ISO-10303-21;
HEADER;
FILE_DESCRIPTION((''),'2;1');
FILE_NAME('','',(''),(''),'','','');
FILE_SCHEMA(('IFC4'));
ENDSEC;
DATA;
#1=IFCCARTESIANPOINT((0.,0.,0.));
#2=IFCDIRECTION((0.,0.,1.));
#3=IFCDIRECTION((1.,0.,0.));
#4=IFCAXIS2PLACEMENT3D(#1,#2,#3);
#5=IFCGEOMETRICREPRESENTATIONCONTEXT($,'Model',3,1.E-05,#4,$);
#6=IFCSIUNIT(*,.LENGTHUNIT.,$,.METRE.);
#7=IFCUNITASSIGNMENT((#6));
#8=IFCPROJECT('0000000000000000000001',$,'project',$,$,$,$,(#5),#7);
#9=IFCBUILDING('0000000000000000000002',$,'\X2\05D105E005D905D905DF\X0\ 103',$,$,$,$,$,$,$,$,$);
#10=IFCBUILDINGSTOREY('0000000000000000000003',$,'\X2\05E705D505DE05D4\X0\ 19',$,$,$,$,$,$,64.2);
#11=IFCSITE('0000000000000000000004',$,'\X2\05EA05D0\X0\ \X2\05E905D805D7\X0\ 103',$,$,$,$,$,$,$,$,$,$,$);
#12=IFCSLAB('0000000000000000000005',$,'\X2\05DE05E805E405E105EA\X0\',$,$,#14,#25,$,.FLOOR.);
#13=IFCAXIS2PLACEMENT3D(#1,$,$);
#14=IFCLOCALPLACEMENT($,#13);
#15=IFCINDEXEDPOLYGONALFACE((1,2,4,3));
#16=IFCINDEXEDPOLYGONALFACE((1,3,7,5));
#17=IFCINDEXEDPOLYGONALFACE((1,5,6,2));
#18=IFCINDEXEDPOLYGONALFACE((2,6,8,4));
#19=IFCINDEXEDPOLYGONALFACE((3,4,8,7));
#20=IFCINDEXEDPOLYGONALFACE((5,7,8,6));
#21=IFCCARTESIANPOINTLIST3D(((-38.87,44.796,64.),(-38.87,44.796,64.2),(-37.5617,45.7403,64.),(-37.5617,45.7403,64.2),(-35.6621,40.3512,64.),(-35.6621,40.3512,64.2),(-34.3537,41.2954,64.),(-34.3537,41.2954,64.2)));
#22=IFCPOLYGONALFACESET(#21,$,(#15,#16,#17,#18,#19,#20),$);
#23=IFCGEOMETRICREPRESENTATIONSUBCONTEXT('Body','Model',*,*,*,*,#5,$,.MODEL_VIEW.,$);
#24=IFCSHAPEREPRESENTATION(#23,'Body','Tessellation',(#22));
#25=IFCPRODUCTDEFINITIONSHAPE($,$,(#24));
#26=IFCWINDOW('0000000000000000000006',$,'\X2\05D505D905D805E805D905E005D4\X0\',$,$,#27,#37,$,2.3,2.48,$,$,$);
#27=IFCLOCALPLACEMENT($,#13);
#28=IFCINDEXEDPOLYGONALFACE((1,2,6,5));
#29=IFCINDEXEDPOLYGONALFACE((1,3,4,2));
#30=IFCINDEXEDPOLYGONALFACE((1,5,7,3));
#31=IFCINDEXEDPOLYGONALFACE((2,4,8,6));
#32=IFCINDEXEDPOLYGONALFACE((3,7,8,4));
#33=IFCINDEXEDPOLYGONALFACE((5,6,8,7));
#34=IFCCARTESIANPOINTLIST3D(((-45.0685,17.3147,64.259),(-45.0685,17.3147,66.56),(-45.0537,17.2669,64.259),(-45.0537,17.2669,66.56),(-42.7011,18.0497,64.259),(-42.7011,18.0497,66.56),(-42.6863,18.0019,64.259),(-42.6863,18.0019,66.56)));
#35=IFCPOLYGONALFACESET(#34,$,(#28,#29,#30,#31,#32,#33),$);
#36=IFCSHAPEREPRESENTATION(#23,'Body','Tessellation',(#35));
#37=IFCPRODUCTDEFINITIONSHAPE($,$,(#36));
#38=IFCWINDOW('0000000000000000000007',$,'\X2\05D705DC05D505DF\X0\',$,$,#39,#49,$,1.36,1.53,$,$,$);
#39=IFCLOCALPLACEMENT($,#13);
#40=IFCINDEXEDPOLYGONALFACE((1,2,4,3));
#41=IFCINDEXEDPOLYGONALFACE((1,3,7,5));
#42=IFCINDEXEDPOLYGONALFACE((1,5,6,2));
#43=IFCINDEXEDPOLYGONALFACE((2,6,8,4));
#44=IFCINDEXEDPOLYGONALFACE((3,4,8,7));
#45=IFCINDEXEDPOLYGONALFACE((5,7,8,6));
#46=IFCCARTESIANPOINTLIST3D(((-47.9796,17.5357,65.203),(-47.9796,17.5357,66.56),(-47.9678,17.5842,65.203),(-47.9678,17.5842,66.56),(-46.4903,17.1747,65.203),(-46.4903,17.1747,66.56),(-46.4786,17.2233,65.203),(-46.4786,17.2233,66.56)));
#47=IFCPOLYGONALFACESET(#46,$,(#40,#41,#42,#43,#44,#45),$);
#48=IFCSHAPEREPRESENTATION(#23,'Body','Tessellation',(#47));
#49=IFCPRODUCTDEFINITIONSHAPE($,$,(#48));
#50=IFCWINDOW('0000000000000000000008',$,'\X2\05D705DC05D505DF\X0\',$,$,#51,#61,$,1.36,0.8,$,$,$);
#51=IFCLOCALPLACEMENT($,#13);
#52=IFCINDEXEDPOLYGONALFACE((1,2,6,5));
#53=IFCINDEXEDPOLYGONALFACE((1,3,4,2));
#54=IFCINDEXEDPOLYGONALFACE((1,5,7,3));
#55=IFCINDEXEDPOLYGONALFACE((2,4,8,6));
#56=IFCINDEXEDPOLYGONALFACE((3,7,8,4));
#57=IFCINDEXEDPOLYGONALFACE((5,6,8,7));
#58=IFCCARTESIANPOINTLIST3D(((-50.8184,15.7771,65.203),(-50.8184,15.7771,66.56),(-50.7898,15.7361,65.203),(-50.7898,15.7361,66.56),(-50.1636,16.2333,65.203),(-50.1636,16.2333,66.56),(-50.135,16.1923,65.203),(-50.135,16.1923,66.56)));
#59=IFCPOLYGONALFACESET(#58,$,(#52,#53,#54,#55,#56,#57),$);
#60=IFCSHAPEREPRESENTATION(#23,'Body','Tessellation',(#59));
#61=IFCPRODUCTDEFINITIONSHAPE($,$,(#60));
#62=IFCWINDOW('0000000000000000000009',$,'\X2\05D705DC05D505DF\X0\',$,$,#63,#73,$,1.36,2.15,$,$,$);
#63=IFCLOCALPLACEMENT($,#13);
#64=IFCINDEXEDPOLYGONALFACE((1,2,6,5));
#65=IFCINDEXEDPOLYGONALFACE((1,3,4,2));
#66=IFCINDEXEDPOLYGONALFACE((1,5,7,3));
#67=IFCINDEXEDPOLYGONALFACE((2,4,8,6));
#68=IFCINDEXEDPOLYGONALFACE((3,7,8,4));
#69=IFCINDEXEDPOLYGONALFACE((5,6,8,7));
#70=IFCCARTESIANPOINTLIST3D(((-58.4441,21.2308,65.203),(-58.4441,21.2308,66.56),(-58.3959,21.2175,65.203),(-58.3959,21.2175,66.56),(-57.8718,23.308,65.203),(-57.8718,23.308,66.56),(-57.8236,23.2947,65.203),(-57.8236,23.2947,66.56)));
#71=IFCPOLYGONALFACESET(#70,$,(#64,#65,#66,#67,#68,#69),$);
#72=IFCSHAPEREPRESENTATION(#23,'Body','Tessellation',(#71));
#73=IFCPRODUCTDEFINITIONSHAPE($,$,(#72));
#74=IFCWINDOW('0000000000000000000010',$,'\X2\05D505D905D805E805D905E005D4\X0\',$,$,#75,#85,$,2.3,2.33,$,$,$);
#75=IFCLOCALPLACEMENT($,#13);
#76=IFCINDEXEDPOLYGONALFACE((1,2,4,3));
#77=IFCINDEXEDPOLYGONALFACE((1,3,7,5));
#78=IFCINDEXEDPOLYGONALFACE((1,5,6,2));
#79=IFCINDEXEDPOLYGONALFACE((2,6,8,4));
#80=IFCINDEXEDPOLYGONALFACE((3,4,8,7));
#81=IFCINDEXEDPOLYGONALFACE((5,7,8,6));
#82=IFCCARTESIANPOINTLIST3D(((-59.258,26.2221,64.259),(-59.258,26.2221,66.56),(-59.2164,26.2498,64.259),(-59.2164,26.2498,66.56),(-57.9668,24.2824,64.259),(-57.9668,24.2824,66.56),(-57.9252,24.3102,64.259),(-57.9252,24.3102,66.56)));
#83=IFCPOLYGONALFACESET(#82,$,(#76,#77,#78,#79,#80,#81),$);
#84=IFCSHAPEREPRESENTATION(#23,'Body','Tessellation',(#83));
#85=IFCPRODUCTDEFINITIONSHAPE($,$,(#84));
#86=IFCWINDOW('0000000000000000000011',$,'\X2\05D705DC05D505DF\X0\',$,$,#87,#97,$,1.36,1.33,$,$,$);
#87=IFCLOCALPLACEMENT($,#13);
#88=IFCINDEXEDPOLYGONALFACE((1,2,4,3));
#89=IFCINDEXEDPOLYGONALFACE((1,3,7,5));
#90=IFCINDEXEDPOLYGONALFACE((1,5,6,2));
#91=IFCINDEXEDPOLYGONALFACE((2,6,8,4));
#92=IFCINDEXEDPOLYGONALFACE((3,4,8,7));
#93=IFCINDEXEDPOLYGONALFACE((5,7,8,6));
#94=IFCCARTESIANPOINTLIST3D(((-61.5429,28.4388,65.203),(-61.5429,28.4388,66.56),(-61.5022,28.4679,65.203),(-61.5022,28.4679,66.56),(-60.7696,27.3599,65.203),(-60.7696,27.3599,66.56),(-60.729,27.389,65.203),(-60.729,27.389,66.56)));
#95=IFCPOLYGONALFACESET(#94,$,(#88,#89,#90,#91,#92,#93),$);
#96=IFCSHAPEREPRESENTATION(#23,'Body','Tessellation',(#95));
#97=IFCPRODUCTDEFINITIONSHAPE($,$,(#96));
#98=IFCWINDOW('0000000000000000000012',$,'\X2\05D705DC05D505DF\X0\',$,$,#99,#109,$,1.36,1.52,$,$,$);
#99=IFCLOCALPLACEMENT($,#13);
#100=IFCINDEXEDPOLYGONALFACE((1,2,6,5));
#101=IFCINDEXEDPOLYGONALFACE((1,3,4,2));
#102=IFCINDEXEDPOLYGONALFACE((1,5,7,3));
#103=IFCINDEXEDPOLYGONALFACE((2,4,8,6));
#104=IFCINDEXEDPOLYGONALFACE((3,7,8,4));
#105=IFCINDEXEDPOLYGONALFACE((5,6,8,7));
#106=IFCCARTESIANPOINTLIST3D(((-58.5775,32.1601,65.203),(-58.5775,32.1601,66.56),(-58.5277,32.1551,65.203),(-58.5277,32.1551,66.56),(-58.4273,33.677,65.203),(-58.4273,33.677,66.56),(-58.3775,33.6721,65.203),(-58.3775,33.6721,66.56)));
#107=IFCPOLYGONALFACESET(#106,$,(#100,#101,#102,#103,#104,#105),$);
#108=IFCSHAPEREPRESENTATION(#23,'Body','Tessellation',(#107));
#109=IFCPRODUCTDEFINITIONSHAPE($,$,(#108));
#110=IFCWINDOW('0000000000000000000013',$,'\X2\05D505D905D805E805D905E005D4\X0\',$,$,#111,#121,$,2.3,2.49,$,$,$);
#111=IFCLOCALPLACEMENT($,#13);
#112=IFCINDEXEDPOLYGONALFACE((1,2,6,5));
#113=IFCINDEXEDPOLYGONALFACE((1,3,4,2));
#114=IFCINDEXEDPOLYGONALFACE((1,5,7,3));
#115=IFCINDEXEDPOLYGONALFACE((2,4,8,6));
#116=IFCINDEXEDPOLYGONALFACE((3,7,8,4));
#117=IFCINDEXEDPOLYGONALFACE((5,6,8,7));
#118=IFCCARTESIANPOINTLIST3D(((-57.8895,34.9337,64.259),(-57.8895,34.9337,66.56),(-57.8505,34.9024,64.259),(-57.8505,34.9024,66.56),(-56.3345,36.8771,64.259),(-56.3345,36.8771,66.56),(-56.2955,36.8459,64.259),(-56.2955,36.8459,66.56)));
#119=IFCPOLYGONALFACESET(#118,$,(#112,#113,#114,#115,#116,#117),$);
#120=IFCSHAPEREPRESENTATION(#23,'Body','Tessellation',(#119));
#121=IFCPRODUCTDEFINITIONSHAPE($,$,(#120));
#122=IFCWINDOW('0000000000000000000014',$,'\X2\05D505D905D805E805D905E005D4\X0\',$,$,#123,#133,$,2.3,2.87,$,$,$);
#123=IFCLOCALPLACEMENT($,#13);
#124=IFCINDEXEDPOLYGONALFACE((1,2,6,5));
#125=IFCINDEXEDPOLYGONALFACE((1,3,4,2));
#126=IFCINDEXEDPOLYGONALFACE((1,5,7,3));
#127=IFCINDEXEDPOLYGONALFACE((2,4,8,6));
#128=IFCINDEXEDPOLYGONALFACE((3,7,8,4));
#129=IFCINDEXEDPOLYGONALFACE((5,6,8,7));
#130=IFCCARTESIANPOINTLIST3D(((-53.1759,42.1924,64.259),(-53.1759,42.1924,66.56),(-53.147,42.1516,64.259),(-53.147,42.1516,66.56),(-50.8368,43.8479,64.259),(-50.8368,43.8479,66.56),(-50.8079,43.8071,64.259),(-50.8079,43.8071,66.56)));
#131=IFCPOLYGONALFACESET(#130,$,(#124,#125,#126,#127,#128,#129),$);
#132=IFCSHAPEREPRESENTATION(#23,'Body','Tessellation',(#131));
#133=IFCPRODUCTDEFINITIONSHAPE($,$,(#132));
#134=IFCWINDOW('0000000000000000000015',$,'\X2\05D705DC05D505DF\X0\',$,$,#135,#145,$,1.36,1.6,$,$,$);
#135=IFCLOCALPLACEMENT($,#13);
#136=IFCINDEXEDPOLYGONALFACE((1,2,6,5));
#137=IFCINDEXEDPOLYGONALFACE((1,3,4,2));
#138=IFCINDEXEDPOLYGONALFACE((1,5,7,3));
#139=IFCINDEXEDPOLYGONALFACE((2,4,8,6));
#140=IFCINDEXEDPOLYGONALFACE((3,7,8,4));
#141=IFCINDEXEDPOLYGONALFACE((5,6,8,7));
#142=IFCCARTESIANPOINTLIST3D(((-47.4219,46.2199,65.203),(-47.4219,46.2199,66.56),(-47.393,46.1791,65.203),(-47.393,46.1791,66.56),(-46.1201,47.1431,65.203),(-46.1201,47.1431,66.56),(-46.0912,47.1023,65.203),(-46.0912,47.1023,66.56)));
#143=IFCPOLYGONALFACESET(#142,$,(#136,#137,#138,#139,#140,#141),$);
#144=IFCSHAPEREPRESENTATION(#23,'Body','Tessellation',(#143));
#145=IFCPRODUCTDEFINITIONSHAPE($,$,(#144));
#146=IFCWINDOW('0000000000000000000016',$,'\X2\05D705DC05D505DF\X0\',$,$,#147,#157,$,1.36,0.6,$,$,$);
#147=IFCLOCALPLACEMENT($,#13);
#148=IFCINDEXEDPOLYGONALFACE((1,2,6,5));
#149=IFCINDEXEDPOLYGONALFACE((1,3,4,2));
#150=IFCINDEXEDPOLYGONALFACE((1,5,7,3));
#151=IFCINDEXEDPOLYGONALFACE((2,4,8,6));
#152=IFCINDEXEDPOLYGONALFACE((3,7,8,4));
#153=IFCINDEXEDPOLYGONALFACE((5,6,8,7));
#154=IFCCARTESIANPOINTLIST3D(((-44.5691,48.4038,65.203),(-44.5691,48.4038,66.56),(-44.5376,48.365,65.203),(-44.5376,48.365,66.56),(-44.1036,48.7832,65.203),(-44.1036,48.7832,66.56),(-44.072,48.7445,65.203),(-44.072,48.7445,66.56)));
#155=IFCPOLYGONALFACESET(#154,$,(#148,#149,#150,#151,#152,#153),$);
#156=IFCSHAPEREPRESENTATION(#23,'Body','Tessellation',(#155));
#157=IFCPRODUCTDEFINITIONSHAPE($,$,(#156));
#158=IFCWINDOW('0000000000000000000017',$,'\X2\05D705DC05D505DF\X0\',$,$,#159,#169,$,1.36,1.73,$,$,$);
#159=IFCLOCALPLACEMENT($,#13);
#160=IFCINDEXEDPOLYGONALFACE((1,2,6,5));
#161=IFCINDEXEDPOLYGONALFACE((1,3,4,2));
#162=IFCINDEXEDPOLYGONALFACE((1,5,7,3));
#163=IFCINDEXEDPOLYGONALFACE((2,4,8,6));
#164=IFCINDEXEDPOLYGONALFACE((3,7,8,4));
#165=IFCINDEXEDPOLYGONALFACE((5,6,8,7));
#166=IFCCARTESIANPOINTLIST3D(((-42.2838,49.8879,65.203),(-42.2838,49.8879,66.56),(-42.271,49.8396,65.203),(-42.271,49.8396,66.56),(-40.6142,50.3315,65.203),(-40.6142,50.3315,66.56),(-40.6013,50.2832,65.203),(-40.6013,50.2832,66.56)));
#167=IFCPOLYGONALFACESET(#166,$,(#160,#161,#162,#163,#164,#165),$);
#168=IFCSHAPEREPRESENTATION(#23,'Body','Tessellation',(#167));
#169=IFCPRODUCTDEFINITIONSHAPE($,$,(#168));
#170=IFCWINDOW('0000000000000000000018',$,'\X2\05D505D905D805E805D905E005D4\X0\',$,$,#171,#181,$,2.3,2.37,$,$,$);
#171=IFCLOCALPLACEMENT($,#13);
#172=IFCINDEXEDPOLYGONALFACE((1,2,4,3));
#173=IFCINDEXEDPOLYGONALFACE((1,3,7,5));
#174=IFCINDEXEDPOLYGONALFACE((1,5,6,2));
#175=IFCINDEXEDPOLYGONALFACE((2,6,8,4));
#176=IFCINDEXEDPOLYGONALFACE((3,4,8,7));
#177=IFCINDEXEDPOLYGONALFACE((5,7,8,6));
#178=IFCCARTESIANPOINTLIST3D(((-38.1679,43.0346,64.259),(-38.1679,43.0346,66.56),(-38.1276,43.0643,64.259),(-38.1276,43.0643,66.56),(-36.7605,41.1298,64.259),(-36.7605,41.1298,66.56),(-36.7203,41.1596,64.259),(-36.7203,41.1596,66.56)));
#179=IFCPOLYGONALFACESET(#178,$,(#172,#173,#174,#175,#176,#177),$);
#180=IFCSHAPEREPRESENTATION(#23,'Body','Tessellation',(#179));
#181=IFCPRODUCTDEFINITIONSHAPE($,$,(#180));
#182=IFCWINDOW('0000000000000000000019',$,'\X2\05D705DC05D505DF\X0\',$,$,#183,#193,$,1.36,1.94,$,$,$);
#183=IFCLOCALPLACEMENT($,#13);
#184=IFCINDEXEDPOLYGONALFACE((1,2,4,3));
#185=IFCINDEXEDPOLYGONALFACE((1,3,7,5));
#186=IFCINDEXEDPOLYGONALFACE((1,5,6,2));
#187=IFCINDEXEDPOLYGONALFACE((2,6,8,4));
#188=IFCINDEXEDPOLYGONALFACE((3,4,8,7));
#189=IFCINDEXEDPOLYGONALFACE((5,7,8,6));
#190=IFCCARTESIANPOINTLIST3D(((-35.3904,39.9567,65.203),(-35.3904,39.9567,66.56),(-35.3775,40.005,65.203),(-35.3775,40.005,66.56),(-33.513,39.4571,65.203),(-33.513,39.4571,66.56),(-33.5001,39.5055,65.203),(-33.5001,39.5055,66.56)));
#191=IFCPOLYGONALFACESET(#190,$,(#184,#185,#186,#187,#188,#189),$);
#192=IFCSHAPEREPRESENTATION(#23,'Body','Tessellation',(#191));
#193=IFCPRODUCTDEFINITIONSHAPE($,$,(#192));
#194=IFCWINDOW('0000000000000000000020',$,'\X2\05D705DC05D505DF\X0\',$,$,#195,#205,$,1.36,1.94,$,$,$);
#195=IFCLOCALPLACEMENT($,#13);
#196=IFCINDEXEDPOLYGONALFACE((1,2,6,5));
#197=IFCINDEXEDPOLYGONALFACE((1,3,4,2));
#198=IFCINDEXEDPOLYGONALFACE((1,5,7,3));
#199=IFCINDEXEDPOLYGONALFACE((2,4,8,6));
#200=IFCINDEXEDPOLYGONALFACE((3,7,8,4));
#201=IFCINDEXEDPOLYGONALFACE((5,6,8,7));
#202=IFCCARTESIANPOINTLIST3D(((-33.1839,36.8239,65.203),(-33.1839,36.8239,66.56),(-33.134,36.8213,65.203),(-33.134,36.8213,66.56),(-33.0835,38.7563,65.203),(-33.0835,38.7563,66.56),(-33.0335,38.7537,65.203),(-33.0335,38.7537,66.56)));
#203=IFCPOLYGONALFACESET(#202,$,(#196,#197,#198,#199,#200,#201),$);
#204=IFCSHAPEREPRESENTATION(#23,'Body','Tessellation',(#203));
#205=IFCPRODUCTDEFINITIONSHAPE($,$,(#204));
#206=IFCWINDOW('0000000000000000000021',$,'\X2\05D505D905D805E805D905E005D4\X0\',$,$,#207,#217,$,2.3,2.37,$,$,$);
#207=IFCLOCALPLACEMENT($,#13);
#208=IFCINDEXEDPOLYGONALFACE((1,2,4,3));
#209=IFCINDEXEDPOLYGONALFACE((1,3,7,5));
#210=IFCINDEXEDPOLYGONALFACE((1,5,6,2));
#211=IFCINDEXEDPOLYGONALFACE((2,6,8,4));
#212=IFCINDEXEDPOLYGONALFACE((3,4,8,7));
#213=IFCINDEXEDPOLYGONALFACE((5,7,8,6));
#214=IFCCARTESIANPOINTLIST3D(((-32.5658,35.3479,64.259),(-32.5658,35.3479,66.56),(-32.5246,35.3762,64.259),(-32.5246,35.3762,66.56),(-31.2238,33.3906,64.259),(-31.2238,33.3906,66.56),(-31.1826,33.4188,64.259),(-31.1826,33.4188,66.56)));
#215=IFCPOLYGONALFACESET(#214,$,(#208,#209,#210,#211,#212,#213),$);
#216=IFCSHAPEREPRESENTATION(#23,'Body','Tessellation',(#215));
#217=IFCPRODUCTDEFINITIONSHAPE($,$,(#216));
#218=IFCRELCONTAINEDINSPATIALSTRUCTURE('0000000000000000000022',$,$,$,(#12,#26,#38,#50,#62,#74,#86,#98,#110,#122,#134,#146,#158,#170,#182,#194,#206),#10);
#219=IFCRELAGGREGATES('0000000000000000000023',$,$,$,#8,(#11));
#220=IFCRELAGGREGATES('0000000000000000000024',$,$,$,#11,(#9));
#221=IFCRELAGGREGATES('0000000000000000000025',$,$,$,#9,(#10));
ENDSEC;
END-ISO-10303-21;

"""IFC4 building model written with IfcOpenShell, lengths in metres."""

from ifc_helpers import new_model, si_unit, frame, origin_with_axes, context, subcontext, project, spatial, polyline, outline, extrude, element, save


model = new_model("IFC4")

# Units and contexts
model_context = context("Model", 3, precision=1e-05, world=origin_with_axes())
body_context = subcontext(model_context, "Body", "Model", "MODEL_VIEW")
ifc_project = project(units=[si_unit("LENGTHUNIT", "METRE")], contexts=[model_context])

# Site, building, storey
site = spatial("IfcSite", under=ifc_project, Name="תא שטח 103")
building = spatial("IfcBuilding", under=site, Name="בניין 103")
storey = spatial("IfcBuildingStorey", under=building, Name="קומה 19", Elevation=64.2)

# Slab
element("IfcSlab", 1, inside=storey, Name="מרפסת", PredefinedType="FLOOR", context=body_context, shape_type="SweptSolid", body=[
    extrude(outline(polyline([(-34.3537, 41.2954), (-37.5617, 45.7403), (-38.87, 44.796), (-35.6621, 40.3512), (-34.3537, 41.2954)])), frame((0.0, 0.0, 64.0)), (0.0, 0.0, 1.0), 0.2),
])

# Windows
element("IfcWindow", 2, inside=storey, Name="ויטרינה", OverallHeight=2.3, OverallWidth=2.48, context=body_context, shape_type="SweptSolid", body=[
    extrude(outline(polyline([(-42.7011, 18.0497), (-45.0685, 17.3147), (-45.0537, 17.2669), (-42.6863, 18.0019), (-42.7011, 18.0497)])), frame((0.0, 0.0, 64.259)), (0.0, 0.0, 1.0), 2.301),
])
element("IfcWindow", 3, inside=storey, Name="חלון", OverallHeight=1.36, OverallWidth=1.53, context=body_context, shape_type="SweptSolid", body=[
    extrude(outline(polyline([(-46.4786, 17.2233), (-47.9678, 17.5842), (-47.9796, 17.5357), (-46.4903, 17.1747), (-46.4786, 17.2233)])), frame((0.0, 0.0, 65.203)), (0.0, 0.0, 1.0), 1.357),
])
element("IfcWindow", 4, inside=storey, Name="חלון", OverallHeight=1.36, OverallWidth=0.8, context=body_context, shape_type="SweptSolid", body=[
    extrude(outline(polyline([(-50.1636, 16.2333), (-50.8184, 15.7771), (-50.7898, 15.7361), (-50.135, 16.1923), (-50.1636, 16.2333)])), frame((0.0, 0.0, 65.203)), (0.0, 0.0, 1.0), 1.357),
])
element("IfcWindow", 5, inside=storey, Name="חלון", OverallHeight=1.36, OverallWidth=2.15, context=body_context, shape_type="SweptSolid", body=[
    extrude(outline(polyline([(-58.3959, 21.2175), (-57.8236, 23.2947), (-57.8718, 23.308), (-58.4441, 21.2308), (-58.3959, 21.2175)])), frame((0.0, 0.0, 65.203)), (0.0, 0.0, 1.0), 1.357),
])
element("IfcWindow", 6, inside=storey, Name="ויטרינה", OverallHeight=2.3, OverallWidth=2.33, context=body_context, shape_type="SweptSolid", body=[
    extrude(outline(polyline([(-57.9252, 24.3102), (-59.2164, 26.2498), (-59.258, 26.2221), (-57.9668, 24.2824), (-57.9252, 24.3102)])), frame((0.0, 0.0, 64.259)), (0.0, 0.0, 1.0), 2.301),
])
element("IfcWindow", 7, inside=storey, Name="חלון", OverallHeight=1.36, OverallWidth=1.33, context=body_context, shape_type="SweptSolid", body=[
    extrude(outline(polyline([(-60.729, 27.389), (-61.5022, 28.4679), (-61.5429, 28.4388), (-60.7696, 27.3599), (-60.729, 27.389)])), frame((0.0, 0.0, 65.203)), (0.0, 0.0, 1.0), 1.357),
])
element("IfcWindow", 8, inside=storey, Name="חלון", OverallHeight=1.36, OverallWidth=1.52, context=body_context, shape_type="SweptSolid", body=[
    extrude(outline(polyline([(-58.5277, 32.1551), (-58.3775, 33.6721), (-58.4273, 33.677), (-58.5775, 32.1601), (-58.5277, 32.1551)])), frame((0.0, 0.0, 65.203)), (0.0, 0.0, 1.0), 1.357),
])
element("IfcWindow", 9, inside=storey, Name="ויטרינה", OverallHeight=2.3, OverallWidth=2.49, context=body_context, shape_type="SweptSolid", body=[
    extrude(outline(polyline([(-57.8505, 34.9024), (-56.2955, 36.8459), (-56.3345, 36.8771), (-57.8895, 34.9337), (-57.8505, 34.9024)])), frame((0.0, 0.0, 64.259)), (0.0, 0.0, 1.0), 2.301),
])
element("IfcWindow", 10, inside=storey, Name="ויטרינה", OverallHeight=2.3, OverallWidth=2.87, context=body_context, shape_type="SweptSolid", body=[
    extrude(outline(polyline([(-53.147, 42.1516), (-50.8079, 43.8071), (-50.8368, 43.8479), (-53.1759, 42.1924), (-53.147, 42.1516)])), frame((0.0, 0.0, 64.259)), (0.0, 0.0, 1.0), 2.301),
])
element("IfcWindow", 11, inside=storey, Name="חלון", OverallHeight=1.36, OverallWidth=1.6, context=body_context, shape_type="SweptSolid", body=[
    extrude(outline(polyline([(-47.393, 46.1791), (-46.0912, 47.1023), (-46.1201, 47.1431), (-47.4219, 46.2199), (-47.393, 46.1791)])), frame((0.0, 0.0, 65.203)), (0.0, 0.0, 1.0), 1.357),
])
element("IfcWindow", 12, inside=storey, Name="חלון", OverallHeight=1.36, OverallWidth=0.6, context=body_context, shape_type="SweptSolid", body=[
    extrude(outline(polyline([(-44.5376, 48.365), (-44.072, 48.7445), (-44.1036, 48.7832), (-44.5691, 48.4038), (-44.5376, 48.365)])), frame((0.0, 0.0, 65.203)), (0.0, 0.0, 1.0), 1.357),
])
element("IfcWindow", 13, inside=storey, Name="חלון", OverallHeight=1.36, OverallWidth=1.73, context=body_context, shape_type="SweptSolid", body=[
    extrude(outline(polyline([(-42.271, 49.8396), (-40.6013, 50.2832), (-40.6142, 50.3315), (-42.2838, 49.8879), (-42.271, 49.8396)])), frame((0.0, 0.0, 65.203)), (0.0, 0.0, 1.0), 1.357),
])
element("IfcWindow", 14, inside=storey, Name="ויטרינה", OverallHeight=2.3, OverallWidth=2.37, context=body_context, shape_type="SweptSolid", body=[
    extrude(outline(polyline([(-38.1679, 43.0346), (-36.7605, 41.1298), (-36.7203, 41.1596), (-38.1276, 43.0643), (-38.1679, 43.0346)])), frame((0.0, 0.0, 64.259)), (0.0, 0.0, 1.0), 2.301),
])
element("IfcWindow", 15, inside=storey, Name="חלון", OverallHeight=1.36, OverallWidth=1.94, context=body_context, shape_type="SweptSolid", body=[
    extrude(outline(polyline([(-35.3904, 39.9567), (-33.513, 39.4571), (-33.5001, 39.5055), (-35.3775, 40.005), (-35.3904, 39.9567)])), frame((0.0, 0.0, 65.203)), (0.0, 0.0, 1.0), 1.357),
])
element("IfcWindow", 16, inside=storey, Name="חלון", OverallHeight=1.36, OverallWidth=1.94, context=body_context, shape_type="SweptSolid", body=[
    extrude(outline(polyline([(-33.0835, 38.7563), (-33.1839, 36.8239), (-33.134, 36.8213), (-33.0335, 38.7537), (-33.0835, 38.7563)])), frame((0.0, 0.0, 65.203)), (0.0, 0.0, 1.0), 1.357),
])
element("IfcWindow", 17, inside=storey, Name="ויטרינה", OverallHeight=2.3, OverallWidth=2.37, context=body_context, shape_type="SweptSolid", body=[
    extrude(outline(polyline([(-32.5658, 35.3479), (-31.2238, 33.3906), (-31.1826, 33.4188), (-32.5246, 35.3762), (-32.5658, 35.3479)])), frame((0.0, 0.0, 64.259)), (0.0, 0.0, 1.0), 2.301),
])

save(model, "model.ifc")
